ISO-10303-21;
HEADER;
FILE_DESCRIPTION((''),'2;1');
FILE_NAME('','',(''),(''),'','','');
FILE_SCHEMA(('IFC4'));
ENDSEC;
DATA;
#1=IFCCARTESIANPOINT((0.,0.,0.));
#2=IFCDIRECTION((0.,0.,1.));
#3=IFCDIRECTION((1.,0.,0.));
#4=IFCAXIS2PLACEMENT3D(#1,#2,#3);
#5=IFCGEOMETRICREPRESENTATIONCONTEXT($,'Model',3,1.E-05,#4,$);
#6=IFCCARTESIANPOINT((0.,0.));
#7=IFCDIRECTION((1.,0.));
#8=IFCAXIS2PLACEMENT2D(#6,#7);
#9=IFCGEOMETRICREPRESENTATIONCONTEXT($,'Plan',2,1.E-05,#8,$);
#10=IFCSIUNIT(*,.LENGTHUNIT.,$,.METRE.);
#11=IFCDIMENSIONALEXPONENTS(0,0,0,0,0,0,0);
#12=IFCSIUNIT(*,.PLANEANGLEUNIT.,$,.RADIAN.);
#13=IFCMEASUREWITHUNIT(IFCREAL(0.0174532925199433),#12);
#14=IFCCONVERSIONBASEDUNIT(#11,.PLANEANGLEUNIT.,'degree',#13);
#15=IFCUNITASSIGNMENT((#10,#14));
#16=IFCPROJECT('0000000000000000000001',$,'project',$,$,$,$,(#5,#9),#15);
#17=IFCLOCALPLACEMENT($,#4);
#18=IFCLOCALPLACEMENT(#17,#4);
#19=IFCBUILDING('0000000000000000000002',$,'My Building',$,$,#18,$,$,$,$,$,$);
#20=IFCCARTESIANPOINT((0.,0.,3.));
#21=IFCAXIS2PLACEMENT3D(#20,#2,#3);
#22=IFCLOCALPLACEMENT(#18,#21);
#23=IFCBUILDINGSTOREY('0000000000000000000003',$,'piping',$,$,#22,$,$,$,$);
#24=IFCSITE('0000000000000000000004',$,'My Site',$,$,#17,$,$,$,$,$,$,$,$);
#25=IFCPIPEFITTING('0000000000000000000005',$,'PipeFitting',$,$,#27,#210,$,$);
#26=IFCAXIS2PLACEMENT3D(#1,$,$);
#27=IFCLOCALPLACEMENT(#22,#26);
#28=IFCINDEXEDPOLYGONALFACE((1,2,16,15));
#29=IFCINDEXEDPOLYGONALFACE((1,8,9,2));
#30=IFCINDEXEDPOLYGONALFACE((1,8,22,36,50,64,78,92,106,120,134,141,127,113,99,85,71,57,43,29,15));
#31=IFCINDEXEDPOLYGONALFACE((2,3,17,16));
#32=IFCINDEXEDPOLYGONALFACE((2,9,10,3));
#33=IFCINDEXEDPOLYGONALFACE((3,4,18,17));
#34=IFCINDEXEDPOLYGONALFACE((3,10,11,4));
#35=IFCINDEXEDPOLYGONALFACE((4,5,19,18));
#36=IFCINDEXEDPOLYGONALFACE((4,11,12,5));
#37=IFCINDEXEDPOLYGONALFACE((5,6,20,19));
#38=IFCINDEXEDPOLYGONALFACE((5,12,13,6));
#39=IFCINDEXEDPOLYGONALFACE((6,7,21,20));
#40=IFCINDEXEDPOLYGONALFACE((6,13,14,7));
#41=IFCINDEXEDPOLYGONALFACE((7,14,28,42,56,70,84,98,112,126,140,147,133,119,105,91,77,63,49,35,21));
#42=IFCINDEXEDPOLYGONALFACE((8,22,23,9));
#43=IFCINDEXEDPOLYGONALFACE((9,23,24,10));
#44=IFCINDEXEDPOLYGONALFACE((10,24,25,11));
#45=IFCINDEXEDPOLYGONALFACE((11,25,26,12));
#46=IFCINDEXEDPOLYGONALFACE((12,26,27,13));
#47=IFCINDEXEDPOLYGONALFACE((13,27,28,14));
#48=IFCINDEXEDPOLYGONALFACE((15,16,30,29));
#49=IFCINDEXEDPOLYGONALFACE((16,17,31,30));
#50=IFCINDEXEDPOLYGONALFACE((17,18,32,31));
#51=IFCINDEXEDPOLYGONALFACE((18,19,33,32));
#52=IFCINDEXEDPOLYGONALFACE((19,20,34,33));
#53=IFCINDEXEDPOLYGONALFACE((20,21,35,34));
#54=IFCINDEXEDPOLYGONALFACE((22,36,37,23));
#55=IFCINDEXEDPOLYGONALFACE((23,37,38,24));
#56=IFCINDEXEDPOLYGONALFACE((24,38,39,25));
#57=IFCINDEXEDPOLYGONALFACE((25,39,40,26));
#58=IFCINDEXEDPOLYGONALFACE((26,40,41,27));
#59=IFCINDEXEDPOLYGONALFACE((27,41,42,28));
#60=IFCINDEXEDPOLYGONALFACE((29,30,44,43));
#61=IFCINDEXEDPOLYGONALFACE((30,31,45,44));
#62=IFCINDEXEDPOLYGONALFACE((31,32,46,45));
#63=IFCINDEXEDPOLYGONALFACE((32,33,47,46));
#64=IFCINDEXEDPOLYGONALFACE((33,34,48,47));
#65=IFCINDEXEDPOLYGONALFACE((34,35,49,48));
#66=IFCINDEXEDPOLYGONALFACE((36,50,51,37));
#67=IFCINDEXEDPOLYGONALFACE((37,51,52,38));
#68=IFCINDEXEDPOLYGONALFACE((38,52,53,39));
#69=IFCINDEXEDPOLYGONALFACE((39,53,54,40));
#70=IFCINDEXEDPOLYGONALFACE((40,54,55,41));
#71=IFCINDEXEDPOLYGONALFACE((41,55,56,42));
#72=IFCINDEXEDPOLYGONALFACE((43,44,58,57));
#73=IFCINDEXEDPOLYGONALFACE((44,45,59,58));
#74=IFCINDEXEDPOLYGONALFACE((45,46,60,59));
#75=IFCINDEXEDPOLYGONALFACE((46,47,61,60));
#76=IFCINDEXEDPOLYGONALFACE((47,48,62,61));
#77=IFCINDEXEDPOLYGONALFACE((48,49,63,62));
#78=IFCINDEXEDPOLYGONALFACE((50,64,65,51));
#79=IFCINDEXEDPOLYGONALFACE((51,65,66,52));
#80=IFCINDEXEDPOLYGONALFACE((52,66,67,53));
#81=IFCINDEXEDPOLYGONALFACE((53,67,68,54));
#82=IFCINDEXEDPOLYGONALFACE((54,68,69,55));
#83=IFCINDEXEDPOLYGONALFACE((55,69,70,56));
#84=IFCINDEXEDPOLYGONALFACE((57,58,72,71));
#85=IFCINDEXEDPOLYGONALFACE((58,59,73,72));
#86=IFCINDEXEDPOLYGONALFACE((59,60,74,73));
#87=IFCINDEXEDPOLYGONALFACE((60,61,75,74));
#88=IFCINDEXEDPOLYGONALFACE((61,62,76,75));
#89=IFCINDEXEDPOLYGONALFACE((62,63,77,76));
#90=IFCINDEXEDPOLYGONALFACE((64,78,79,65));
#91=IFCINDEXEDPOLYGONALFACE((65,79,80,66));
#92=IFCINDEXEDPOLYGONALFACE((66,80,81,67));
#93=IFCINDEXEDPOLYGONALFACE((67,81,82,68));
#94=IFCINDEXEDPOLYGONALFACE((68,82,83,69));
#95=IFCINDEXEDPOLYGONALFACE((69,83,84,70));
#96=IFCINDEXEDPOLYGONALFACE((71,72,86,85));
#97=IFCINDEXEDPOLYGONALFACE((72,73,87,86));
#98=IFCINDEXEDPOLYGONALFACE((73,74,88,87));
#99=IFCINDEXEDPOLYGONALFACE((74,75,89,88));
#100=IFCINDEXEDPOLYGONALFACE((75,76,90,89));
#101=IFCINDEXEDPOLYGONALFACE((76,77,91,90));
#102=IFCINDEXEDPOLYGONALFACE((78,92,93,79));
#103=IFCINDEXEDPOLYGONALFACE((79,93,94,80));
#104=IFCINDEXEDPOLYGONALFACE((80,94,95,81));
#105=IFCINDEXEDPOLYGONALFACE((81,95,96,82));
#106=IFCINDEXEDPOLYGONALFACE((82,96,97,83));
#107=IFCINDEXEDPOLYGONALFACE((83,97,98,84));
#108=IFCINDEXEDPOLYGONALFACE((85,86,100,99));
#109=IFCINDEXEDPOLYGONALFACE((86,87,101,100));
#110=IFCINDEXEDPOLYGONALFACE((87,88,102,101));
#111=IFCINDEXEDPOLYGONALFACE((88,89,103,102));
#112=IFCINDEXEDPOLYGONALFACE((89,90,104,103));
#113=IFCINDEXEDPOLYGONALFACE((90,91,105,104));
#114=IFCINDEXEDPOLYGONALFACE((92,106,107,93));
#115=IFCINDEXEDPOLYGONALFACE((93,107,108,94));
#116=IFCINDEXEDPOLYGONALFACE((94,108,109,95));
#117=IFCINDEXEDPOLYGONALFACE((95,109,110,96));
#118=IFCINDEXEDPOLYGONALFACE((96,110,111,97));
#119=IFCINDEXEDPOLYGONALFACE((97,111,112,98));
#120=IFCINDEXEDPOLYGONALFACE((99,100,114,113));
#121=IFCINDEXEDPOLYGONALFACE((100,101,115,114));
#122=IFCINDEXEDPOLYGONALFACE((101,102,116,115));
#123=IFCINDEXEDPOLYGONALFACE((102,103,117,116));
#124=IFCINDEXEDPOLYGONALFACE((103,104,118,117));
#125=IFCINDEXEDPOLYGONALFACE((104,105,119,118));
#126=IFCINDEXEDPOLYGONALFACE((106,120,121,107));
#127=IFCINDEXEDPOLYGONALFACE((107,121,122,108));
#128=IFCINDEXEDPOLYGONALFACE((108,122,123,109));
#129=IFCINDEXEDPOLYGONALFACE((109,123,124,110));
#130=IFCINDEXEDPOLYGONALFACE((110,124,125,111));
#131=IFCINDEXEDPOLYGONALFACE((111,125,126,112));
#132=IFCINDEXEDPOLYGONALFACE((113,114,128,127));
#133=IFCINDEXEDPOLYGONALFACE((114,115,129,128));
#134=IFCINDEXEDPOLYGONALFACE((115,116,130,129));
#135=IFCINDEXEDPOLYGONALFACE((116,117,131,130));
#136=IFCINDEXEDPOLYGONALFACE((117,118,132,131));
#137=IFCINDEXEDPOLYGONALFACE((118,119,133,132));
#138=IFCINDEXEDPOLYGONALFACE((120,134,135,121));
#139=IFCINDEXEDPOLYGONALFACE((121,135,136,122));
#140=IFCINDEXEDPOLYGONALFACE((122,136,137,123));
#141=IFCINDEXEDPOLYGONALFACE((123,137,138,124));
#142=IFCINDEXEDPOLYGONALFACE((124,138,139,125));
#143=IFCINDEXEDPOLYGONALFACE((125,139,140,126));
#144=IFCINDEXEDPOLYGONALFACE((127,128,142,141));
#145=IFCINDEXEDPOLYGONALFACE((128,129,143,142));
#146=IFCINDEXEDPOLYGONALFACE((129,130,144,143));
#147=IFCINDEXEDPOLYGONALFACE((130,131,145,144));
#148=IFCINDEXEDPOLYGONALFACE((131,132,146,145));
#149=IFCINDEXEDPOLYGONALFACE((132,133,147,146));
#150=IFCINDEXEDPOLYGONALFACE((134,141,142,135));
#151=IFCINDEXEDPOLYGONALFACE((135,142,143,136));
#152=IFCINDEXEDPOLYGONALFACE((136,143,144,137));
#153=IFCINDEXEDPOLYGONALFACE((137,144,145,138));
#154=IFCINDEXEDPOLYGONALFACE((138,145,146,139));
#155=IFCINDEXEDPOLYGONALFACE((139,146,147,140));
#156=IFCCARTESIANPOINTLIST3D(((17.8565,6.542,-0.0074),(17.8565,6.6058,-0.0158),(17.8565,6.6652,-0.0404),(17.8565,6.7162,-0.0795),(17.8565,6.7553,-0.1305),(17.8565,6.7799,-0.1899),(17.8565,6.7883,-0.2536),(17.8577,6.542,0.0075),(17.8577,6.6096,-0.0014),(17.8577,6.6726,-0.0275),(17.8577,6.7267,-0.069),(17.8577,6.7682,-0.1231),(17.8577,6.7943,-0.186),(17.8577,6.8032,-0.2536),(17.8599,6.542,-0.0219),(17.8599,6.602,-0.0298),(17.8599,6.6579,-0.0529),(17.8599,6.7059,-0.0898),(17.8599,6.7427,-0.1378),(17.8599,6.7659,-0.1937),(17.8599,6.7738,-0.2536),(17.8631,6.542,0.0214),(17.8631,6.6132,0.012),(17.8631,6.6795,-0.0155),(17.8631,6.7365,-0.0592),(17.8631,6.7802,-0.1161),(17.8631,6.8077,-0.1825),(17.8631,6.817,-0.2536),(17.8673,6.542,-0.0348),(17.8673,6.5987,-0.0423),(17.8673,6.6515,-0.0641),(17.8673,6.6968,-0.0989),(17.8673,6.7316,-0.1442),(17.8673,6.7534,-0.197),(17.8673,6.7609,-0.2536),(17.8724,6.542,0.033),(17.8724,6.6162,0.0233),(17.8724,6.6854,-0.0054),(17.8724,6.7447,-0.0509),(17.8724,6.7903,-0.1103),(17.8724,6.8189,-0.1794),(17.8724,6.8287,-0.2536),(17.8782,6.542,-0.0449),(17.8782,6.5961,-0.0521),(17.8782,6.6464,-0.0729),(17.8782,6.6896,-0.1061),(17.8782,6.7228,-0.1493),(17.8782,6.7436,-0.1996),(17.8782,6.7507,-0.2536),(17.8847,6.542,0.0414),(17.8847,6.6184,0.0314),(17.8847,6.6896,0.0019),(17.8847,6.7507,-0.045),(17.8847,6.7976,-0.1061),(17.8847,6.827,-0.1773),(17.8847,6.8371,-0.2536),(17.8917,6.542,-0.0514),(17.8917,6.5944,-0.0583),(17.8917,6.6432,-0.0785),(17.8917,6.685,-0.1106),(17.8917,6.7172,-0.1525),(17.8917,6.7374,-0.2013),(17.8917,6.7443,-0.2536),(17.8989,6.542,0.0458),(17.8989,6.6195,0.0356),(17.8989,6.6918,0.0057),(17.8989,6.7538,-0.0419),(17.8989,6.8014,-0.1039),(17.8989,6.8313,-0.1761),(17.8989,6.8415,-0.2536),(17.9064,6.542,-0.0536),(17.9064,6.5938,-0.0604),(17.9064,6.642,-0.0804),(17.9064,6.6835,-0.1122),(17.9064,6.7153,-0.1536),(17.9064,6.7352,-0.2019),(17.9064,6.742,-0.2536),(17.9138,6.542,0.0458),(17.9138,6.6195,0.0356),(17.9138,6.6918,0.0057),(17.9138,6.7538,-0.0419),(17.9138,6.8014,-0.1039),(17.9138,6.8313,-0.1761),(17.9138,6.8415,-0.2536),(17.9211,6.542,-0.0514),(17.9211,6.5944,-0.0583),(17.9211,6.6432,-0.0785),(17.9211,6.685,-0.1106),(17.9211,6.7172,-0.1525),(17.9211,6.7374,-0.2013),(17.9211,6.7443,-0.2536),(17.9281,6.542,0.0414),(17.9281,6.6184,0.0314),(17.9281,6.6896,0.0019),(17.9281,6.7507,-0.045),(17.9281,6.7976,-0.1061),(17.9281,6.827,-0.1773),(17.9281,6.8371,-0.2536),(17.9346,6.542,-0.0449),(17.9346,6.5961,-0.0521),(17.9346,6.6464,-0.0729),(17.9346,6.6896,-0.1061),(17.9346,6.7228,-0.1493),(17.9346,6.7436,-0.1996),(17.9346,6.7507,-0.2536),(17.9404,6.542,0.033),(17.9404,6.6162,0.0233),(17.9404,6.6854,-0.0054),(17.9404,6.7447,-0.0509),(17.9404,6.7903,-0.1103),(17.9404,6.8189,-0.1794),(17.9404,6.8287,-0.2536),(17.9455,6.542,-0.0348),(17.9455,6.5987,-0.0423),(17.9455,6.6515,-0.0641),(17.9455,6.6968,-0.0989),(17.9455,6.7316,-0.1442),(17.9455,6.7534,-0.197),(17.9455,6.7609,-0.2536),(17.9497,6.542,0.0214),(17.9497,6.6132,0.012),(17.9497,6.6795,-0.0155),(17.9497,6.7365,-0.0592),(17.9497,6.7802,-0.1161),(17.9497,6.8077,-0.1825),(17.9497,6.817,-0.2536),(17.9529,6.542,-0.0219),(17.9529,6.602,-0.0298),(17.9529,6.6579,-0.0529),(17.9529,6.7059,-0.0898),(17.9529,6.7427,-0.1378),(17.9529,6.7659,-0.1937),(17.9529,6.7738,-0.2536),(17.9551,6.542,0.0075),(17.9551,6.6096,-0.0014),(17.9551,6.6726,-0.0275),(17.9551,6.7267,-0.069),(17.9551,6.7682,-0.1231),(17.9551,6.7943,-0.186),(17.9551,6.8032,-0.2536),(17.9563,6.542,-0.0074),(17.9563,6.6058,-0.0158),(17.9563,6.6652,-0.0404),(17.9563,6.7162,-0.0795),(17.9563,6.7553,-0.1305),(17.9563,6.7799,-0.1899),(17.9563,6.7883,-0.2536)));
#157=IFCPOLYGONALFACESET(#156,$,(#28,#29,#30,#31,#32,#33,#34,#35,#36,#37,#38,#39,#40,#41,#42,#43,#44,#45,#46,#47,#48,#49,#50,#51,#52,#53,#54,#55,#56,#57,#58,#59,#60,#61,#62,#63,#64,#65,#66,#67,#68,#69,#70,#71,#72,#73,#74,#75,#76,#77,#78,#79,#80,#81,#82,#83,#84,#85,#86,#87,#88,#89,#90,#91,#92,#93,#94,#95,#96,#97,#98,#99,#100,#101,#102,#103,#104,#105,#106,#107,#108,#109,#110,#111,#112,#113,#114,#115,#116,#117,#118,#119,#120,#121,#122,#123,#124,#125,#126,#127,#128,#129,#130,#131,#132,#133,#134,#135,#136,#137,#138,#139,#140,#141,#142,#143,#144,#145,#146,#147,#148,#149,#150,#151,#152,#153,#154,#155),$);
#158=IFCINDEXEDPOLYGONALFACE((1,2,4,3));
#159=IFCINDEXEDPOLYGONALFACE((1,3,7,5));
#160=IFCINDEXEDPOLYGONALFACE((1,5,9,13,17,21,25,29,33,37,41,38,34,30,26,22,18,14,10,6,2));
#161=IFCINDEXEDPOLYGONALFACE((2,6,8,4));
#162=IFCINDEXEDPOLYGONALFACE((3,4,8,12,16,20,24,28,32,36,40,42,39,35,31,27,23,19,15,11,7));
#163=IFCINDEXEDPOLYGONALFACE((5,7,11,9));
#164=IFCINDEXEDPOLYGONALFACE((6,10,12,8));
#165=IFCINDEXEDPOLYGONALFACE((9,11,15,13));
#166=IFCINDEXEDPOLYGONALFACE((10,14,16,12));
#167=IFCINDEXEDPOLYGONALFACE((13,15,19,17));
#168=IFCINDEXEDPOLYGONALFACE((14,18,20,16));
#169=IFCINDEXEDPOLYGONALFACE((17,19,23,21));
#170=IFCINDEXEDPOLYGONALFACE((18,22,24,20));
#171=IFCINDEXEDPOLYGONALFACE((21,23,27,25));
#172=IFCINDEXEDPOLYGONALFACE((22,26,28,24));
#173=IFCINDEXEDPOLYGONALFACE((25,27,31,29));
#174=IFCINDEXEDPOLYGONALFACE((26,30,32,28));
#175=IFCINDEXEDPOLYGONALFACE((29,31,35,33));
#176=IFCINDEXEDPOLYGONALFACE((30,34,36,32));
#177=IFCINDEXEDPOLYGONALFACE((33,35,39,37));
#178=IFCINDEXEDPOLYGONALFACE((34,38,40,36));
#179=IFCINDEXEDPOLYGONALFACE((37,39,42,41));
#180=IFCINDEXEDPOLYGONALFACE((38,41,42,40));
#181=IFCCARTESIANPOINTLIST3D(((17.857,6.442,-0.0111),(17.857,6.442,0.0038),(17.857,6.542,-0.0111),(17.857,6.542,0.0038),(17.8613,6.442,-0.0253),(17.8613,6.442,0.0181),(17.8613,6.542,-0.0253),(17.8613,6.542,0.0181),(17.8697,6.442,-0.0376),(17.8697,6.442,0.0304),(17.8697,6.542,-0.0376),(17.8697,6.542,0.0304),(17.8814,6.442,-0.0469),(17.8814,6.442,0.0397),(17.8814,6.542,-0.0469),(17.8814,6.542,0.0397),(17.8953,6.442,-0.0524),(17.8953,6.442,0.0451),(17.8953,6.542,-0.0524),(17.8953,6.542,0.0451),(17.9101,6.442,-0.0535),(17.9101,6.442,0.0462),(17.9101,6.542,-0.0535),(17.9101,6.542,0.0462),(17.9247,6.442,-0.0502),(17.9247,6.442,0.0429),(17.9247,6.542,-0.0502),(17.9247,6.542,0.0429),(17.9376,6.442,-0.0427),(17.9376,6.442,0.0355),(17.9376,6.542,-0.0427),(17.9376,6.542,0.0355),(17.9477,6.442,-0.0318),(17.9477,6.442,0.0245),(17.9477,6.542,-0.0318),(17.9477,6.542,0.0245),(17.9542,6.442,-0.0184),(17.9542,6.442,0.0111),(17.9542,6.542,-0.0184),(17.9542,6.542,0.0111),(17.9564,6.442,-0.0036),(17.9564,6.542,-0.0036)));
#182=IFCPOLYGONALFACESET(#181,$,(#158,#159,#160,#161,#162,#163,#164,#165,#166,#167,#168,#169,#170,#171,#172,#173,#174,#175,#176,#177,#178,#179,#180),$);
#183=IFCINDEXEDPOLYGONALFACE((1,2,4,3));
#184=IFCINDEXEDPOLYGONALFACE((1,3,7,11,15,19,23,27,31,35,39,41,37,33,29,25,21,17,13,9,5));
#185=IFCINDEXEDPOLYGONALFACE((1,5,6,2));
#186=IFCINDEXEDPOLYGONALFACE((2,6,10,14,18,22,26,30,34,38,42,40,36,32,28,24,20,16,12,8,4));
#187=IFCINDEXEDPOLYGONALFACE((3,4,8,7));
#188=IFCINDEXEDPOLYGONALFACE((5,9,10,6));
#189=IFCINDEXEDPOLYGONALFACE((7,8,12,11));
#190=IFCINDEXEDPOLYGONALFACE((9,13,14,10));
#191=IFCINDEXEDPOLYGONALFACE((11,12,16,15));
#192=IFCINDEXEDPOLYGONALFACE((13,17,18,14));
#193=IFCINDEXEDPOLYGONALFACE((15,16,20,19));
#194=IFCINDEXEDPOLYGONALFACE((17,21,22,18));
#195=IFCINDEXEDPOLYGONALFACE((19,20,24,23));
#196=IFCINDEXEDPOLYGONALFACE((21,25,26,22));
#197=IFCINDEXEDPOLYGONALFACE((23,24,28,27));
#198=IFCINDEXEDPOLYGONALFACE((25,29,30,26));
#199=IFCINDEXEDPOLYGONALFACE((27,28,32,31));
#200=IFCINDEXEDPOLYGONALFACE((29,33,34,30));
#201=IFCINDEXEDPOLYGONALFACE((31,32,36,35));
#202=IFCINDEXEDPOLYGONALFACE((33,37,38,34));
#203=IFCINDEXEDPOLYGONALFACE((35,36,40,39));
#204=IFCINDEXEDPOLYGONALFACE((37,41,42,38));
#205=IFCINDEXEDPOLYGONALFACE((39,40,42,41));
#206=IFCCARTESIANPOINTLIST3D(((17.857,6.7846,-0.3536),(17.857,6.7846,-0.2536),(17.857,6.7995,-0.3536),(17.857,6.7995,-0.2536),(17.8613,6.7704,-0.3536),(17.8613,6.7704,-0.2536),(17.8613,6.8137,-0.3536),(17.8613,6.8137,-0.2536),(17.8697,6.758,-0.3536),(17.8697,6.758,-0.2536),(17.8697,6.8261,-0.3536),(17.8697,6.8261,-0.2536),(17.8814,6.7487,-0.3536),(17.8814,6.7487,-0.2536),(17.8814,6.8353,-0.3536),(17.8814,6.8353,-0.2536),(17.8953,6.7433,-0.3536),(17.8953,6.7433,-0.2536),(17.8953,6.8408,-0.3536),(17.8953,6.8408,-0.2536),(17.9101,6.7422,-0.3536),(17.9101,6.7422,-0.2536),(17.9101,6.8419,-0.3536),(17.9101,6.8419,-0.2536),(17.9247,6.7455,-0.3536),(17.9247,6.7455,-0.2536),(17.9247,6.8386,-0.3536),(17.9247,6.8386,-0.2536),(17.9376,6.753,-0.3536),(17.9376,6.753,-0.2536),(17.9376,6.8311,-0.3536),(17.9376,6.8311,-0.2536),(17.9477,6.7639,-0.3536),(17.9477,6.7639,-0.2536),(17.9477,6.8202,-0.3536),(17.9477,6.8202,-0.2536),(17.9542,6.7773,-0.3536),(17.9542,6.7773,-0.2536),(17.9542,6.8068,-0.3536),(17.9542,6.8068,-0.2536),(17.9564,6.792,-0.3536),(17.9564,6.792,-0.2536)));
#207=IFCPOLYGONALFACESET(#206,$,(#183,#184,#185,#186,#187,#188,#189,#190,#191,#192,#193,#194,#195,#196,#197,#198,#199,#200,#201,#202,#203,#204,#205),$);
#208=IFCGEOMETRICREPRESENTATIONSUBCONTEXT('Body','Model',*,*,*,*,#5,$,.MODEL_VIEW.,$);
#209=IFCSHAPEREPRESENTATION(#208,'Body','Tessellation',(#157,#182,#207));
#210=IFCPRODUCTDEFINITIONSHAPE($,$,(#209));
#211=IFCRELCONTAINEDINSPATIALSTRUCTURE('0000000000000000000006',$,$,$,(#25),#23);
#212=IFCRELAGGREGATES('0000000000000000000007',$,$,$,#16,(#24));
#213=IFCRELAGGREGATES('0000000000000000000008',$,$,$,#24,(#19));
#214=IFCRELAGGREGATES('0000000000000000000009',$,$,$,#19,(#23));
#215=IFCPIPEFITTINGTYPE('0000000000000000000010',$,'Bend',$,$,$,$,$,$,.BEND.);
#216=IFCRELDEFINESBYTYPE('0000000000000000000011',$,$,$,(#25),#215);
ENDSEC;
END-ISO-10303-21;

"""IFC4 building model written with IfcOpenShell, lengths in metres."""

from ifc_helpers import new_model, entity, si_unit, converted_unit, frame, origin_with_axes, origin_2d_with_axis, place, context, subcontext, project, spatial, circle, extrude, source, transform, mapped, type_object, type_shapes, element, save


model = new_model("IFC4")

# Units and contexts
model_context = context("Model", 3, precision=1e-05, world=origin_with_axes())
plan_context = context("Plan", 2, precision=1e-05, world=origin_2d_with_axis())
body_context = subcontext(model_context, "Body", "Model", "MODEL_VIEW")
ifc_project = project(units=[si_unit("LENGTHUNIT", "METRE"), converted_unit("PLANEANGLEUNIT", "degree", entity("IfcReal", 0.0174532925199433), si_unit("PLANEANGLEUNIT", "RADIAN"), dimensions=[0, 0, 0, 0, 0, 0, 0])], contexts=[model_context, plan_context])

# Site, building, storey
site_placement = place(None, origin_with_axes())
site = spatial("IfcSite", under=ifc_project, at=site_placement, Name="My Site")
building_placement = place(site_placement, origin_with_axes())
building = spatial("IfcBuilding", under=site, at=building_placement, Name="My Building")
storey_placement = place(building_placement, frame((0.0, 0.0, 3.0), z_axis=(0.0, 0.0, 1.0), x_axis=(1.0, 0.0, 0.0)))
storey = spatial("IfcBuildingStorey", under=building, at=storey_placement, Name="piping")

# Pipe fitting
pipe_fitting_type = type_object("IfcPipeFittingType", Name="Bend", PredefinedType="BEND")
shared_shape = source(origin_with_axes(), body_context, "Body", "SolidModel", [
    entity("IfcSweptDiskSolid", entity("IfcIndexedPolyCurve", entity("IfcCartesianPointList3D", [[0.0, 0.0, -0.1], [0.0, -0.0732, -0.2768], [0.0, -0.25, -0.35]]), [entity("IfcArcIndex", [1, 2, 3])]), 0.05),
    extrude(circle(Radius=0.05), origin_with_axes(), (0.0, 0.0, -1.0), 0.1),
    extrude(circle(Radius=0.05), frame((0.0, -0.25, -0.35), z_axis=(0.0, -1.0, 0.0), x_axis=(1.0, 0.0, 0.0)), (0.0, 0.0, 1.0), 0.1),
])
type_shapes(pipe_fitting_type, [shared_shape])
for number, where, z_axis, x_axis, name in (
    (1, (17.9064, 6.442, -0.0036), (0.0, -1.0, 0.0), (1.0, 0.0, 0.0), "PipeFitting"),
):
    element("IfcPipeFitting", number, at=place(storey_placement, frame(where, z_axis=z_axis, x_axis=x_axis)), inside=storey, type_object=pipe_fitting_type, Name=name, context=body_context, shape_type="MappedRepresentation", body=[
        mapped(shared_shape, transform((0.0, 0.0, 0.0), x_axis=(1.0, 0.0, 0.0), y_axis=(0.0, 1.0, 0.0), z_axis=(0.0, 0.0, 1.0), scale=1.0)),
    ])

save(model, "model.ifc")
